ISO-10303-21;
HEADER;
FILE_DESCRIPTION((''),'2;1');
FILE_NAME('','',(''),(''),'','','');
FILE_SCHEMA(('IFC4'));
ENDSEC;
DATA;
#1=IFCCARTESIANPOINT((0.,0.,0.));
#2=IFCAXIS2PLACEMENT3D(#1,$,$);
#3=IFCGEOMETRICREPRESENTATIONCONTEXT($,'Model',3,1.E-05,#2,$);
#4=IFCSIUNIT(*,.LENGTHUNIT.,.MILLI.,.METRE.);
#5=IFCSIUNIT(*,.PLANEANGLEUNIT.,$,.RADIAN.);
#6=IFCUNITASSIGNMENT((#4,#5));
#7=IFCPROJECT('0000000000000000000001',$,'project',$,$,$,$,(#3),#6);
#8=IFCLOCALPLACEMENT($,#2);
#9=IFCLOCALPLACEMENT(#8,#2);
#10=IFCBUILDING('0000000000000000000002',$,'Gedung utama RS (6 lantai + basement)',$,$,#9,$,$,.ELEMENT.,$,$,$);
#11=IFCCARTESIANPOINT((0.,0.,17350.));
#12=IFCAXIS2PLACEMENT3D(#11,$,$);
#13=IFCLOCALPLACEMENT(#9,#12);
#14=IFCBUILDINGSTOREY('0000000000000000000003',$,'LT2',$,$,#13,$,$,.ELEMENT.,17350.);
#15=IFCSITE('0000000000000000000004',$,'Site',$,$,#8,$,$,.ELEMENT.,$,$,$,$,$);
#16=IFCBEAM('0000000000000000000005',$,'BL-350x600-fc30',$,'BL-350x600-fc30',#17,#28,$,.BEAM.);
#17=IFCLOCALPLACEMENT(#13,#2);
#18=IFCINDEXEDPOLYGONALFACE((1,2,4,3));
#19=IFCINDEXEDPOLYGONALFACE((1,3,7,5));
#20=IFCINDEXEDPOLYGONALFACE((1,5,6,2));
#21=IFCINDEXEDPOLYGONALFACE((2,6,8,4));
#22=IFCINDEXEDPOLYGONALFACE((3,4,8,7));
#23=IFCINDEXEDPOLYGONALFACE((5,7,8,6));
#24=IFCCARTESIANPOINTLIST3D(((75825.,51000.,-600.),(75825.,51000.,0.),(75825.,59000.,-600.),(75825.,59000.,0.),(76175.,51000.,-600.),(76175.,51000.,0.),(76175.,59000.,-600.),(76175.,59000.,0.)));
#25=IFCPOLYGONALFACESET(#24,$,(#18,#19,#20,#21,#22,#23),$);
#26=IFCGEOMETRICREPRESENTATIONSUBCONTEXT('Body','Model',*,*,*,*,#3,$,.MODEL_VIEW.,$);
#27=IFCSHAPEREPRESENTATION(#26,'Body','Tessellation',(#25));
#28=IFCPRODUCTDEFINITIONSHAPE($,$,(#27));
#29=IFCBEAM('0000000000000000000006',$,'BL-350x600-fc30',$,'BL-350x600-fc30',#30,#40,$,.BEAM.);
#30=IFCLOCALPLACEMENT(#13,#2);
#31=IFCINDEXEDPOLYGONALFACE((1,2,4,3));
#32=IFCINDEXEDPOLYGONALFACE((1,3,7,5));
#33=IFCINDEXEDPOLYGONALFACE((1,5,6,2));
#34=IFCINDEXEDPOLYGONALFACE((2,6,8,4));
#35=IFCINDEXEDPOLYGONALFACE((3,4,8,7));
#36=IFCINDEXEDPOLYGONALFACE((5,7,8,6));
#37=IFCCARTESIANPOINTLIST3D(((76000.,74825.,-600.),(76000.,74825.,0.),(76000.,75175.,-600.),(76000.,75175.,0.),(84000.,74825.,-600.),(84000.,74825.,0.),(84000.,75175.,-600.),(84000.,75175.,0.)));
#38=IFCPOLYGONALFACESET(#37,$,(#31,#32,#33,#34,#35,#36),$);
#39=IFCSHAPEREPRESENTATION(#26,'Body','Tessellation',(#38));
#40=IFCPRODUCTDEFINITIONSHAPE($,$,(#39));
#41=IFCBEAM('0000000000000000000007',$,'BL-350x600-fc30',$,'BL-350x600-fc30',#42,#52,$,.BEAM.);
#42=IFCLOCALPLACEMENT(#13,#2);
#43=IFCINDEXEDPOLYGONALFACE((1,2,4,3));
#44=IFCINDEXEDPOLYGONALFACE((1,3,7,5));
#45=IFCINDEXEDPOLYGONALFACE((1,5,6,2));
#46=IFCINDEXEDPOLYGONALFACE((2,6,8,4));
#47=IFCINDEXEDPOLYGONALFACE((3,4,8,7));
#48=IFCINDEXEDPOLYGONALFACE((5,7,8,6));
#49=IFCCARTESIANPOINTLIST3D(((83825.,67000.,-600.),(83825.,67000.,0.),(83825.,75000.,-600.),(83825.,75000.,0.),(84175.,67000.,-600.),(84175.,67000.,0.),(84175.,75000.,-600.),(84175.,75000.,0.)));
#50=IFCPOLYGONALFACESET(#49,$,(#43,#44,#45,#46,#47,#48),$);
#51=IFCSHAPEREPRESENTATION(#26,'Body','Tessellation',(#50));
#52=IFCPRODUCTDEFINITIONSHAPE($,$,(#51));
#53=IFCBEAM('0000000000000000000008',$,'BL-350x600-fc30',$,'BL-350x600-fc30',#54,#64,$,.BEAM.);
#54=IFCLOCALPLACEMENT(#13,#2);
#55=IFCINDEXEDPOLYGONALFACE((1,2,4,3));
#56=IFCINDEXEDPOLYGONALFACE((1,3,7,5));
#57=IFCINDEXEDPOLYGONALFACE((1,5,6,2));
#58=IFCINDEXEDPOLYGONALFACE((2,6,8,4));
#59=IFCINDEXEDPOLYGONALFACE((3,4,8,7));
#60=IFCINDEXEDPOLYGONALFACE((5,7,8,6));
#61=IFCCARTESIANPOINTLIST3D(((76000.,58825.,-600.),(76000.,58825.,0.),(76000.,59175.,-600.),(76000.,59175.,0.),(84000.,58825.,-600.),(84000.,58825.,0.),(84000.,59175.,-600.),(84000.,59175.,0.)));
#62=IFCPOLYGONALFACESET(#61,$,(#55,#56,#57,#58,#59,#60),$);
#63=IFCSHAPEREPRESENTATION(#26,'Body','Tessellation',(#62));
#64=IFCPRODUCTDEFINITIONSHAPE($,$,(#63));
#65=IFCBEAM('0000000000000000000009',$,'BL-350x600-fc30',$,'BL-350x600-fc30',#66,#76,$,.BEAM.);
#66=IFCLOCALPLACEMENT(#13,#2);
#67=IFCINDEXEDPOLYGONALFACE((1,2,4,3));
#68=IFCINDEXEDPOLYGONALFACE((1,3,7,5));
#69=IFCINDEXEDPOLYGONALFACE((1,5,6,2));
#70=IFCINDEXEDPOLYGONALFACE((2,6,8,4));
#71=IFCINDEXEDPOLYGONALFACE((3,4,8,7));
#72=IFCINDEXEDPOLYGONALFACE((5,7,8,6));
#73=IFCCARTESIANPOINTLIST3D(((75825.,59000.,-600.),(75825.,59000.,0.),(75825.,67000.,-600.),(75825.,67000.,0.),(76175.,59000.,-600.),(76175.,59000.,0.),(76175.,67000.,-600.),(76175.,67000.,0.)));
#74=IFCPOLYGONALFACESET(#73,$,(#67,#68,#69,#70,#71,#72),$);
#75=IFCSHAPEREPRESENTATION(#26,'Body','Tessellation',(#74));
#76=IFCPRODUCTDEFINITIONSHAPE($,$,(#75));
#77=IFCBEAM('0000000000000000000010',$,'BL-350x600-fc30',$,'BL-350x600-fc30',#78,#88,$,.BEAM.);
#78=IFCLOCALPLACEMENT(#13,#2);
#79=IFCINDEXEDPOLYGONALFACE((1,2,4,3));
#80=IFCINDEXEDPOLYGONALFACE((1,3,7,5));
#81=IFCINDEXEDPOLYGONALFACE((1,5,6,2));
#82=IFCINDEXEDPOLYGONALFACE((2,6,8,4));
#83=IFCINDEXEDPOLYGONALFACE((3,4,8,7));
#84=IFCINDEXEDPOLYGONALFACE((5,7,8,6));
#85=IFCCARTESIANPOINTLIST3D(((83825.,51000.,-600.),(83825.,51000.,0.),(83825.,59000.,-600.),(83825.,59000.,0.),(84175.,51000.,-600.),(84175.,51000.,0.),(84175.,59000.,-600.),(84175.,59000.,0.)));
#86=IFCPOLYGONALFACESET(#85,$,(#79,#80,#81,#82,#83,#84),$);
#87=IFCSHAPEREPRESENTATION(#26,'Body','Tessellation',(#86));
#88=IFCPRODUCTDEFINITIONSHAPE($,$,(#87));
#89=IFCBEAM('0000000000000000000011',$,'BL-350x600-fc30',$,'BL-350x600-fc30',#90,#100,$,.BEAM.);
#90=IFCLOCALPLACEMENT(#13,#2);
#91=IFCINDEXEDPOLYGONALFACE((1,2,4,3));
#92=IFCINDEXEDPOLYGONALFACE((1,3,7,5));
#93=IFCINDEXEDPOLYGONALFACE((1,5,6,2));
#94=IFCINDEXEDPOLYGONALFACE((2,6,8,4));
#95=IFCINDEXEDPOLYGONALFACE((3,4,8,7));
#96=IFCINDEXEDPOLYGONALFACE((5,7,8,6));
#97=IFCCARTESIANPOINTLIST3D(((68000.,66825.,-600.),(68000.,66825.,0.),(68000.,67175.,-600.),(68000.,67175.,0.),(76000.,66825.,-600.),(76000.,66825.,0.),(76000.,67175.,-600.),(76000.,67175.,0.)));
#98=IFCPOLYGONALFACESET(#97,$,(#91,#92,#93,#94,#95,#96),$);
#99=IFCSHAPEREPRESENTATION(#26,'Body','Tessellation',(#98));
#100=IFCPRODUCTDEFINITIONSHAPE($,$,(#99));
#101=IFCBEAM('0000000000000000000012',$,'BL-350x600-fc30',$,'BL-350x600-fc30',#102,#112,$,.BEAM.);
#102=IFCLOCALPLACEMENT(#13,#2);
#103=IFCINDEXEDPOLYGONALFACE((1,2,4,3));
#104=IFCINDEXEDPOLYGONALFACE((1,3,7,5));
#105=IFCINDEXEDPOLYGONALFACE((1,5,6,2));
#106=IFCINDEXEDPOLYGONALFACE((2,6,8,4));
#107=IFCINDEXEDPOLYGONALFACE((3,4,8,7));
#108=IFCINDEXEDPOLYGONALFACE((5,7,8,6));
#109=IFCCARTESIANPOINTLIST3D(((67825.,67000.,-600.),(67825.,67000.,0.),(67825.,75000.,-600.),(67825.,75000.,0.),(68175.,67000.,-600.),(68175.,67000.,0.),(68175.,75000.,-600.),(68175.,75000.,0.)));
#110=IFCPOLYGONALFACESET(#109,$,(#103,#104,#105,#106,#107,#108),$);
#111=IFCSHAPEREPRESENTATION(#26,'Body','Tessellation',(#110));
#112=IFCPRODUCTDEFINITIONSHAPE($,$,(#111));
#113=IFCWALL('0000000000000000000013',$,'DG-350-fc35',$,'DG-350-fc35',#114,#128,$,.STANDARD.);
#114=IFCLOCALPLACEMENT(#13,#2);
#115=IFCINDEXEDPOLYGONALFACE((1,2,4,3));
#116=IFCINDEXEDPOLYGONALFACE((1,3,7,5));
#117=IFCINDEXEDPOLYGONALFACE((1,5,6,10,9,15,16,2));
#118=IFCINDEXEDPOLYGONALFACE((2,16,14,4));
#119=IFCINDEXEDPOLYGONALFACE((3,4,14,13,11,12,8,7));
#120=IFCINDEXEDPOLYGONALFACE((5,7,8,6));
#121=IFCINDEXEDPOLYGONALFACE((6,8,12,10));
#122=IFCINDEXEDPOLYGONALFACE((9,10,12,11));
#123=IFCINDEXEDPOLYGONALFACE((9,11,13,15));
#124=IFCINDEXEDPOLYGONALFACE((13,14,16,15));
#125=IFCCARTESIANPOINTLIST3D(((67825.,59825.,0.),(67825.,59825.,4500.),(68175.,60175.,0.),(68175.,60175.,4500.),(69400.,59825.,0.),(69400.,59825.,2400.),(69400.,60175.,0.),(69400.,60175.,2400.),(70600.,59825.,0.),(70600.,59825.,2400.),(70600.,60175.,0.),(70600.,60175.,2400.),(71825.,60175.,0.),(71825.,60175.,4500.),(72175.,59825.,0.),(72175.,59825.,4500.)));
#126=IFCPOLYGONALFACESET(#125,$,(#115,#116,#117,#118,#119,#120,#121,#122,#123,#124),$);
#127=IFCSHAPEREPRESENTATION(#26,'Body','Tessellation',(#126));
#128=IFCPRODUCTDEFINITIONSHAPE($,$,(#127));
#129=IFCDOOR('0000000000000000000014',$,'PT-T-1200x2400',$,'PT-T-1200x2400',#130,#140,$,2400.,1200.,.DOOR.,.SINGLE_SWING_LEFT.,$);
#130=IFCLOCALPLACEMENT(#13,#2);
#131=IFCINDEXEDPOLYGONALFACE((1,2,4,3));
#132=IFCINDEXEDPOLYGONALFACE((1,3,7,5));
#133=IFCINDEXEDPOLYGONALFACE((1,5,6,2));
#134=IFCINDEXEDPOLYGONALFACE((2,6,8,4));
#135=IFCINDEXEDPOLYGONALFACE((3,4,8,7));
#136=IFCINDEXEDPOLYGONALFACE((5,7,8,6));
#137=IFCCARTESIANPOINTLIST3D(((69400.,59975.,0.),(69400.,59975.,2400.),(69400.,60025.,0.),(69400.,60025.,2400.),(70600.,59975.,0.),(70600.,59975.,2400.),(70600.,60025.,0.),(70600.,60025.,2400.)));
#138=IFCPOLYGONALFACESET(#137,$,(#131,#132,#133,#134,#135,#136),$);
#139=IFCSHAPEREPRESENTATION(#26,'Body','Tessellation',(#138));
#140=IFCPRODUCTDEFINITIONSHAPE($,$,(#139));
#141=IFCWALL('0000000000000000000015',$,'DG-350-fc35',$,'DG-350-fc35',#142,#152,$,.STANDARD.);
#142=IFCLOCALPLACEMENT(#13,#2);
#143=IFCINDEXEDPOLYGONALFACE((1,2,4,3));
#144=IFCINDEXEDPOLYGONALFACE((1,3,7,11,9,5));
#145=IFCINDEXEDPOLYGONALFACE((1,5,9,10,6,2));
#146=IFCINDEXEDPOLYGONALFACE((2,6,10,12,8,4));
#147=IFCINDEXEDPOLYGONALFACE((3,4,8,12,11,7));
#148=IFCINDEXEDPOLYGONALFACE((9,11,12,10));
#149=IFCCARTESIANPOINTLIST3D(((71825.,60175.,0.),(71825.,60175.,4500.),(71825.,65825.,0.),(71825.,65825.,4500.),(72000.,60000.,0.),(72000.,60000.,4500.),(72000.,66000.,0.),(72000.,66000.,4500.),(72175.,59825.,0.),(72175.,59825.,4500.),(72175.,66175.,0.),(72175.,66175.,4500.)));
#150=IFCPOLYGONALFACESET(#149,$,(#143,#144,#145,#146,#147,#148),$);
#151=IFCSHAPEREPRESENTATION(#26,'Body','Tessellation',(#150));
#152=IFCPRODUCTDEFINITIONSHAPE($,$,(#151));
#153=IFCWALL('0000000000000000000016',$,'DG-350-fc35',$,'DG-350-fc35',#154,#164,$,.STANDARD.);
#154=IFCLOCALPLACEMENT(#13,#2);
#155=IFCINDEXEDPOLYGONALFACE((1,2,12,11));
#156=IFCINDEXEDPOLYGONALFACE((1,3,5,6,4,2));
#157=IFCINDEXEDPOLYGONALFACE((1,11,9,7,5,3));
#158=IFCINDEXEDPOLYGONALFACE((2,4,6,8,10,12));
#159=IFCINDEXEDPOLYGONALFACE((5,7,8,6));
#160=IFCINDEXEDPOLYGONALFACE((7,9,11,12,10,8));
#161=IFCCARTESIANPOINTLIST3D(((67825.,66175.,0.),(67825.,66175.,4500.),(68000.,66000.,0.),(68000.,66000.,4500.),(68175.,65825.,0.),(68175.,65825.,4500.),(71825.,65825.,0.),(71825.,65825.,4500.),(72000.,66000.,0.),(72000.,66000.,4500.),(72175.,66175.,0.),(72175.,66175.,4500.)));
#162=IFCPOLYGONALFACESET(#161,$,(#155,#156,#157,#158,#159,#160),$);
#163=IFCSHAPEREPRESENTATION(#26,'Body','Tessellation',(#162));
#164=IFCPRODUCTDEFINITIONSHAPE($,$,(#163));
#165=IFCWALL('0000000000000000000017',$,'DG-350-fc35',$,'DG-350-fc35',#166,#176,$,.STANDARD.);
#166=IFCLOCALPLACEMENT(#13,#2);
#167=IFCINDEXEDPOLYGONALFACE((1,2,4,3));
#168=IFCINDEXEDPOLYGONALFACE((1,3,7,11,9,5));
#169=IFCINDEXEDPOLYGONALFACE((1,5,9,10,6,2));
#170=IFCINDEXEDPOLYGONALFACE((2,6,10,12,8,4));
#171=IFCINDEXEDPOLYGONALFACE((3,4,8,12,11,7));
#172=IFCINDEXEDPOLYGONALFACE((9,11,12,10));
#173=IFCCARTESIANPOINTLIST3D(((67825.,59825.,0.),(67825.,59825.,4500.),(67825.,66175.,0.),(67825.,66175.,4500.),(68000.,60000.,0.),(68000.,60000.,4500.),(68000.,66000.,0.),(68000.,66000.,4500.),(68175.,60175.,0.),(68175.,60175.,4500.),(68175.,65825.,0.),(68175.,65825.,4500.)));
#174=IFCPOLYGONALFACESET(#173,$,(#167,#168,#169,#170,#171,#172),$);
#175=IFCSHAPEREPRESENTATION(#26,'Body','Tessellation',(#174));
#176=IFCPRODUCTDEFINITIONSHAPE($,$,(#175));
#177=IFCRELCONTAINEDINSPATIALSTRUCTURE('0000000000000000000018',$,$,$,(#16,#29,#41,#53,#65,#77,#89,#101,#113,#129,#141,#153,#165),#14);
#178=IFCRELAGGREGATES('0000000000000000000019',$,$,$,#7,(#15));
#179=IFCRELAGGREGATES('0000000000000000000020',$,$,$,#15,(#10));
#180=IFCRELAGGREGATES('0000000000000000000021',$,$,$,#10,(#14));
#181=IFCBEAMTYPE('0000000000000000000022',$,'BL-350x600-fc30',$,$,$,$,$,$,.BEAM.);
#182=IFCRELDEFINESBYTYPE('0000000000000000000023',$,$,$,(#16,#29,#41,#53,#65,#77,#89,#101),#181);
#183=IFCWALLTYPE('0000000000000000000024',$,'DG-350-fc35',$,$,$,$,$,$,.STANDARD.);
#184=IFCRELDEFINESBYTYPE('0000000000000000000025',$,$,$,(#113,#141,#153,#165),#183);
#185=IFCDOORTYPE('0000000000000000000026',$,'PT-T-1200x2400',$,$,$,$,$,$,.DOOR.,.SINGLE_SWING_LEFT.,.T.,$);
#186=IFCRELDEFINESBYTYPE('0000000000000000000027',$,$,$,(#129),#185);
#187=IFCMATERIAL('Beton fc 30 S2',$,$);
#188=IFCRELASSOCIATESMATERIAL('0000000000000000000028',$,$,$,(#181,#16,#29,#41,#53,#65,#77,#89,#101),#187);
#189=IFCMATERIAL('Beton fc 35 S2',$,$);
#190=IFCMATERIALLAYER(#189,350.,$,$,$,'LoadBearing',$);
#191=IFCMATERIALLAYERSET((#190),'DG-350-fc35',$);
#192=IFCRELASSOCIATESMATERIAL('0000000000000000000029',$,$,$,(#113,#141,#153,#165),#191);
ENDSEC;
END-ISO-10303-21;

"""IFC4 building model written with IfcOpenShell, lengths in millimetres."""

from ifc_helpers import new_model, si_unit, frame, frame_2d, origin, origin_2d, place, context, subcontext, project, spatial, polyline, rectangle, outline, extrude, material, layer, layer_set, layer_usage, material_profile, profile_set, profile_usage, type_object, element, fill, save


model = new_model("IFC4")

# Units and contexts
model_context = context("Model", 3, precision=1e-05, world=origin())
body_context = subcontext(model_context, "Body", "Model", "MODEL_VIEW")
ifc_project = project(units=[si_unit("LENGTHUNIT", "METRE", prefix="MILLI"), si_unit("PLANEANGLEUNIT", "RADIAN")], contexts=[model_context])

# Site, building, storey
site_placement = place(None, origin())
site = spatial("IfcSite", under=ifc_project, at=site_placement, Name="Site", CompositionType="ELEMENT")
building_placement = place(site_placement, origin())
building = spatial("IfcBuilding", under=site, at=building_placement, Name="Gedung utama RS (6 lantai + basement)", CompositionType="ELEMENT")
storey_placement = place(building_placement, frame((0.0, 0.0, 17350.0)))
storey = spatial("IfcBuildingStorey", under=building, at=storey_placement, Name="LT2", CompositionType="ELEMENT", Elevation=17350.0)

# Beams
ifc_material_1 = material(Name="Beton fc 30 S2")
ifc_material_profile_1 = material_profile(ifc_material_1, rectangle(XDim=350.0, YDim=600.0, at=origin_2d()), Name="BL-350x600-fc30")
ifc_profile_set_1 = profile_set([ifc_material_profile_1], Name="BL-350x600-fc30")
ifc_profile_usage_1 = profile_usage(ifc_profile_set_1, cardinal=8)
beam_type = type_object("IfcBeamType", Name="BL-350x600-fc30", PredefinedType="BEAM", material=ifc_profile_set_1)
beam_1_placement = place(storey_placement, frame((76000.0, 51000.0, -300.0)))
element("IfcBeam", 1, at=beam_1_placement, inside=storey, type_object=beam_type, material=ifc_profile_usage_1, Name="BL-350x600-fc30", ObjectType="BL-350x600-fc30", PredefinedType="BEAM", context=body_context, shape_type="SweptSolid", body=[
    extrude(rectangle(XDim=350.0, YDim=600.0, at=origin_2d()), frame((0.0, 0.0, 0.0), z_axis=(0.0, 1.0, 0.0), x_axis=(-1.0, 0.0, 0.0)), (0.0, 0.0, 1.0), 8000.0),
])
beam_2_placement = place(storey_placement, frame((76000.0, 75000.0, -300.0)))
element("IfcBeam", 2, at=beam_2_placement, inside=storey, type_object=beam_type, material=ifc_profile_usage_1, Name="BL-350x600-fc30", ObjectType="BL-350x600-fc30", PredefinedType="BEAM", context=body_context, shape_type="SweptSolid", body=[
    extrude(rectangle(XDim=350.0, YDim=600.0, at=origin_2d()), frame((0.0, 0.0, 0.0), z_axis=(1.0, 0.0, 0.0), x_axis=(0.0, 1.0, 0.0)), (0.0, 0.0, 1.0), 8000.0),
])
beam_3_placement = place(storey_placement, frame((84000.0, 67000.0, -300.0)))
element("IfcBeam", 3, at=beam_3_placement, inside=storey, type_object=beam_type, material=ifc_profile_usage_1, Name="BL-350x600-fc30", ObjectType="BL-350x600-fc30", PredefinedType="BEAM", context=body_context, shape_type="SweptSolid", body=[
    extrude(rectangle(XDim=350.0, YDim=600.0, at=origin_2d()), frame((0.0, 0.0, 0.0), z_axis=(0.0, 1.0, 0.0), x_axis=(-1.0, 0.0, 0.0)), (0.0, 0.0, 1.0), 8000.0),
])
beam_4_placement = place(storey_placement, frame((76000.0, 59000.0, -300.0)))
element("IfcBeam", 4, at=beam_4_placement, inside=storey, type_object=beam_type, material=ifc_profile_usage_1, Name="BL-350x600-fc30", ObjectType="BL-350x600-fc30", PredefinedType="BEAM", context=body_context, shape_type="SweptSolid", body=[
    extrude(rectangle(XDim=350.0, YDim=600.0, at=origin_2d()), frame((0.0, 0.0, 0.0), z_axis=(1.0, 0.0, 0.0), x_axis=(0.0, 1.0, 0.0)), (0.0, 0.0, 1.0), 8000.0),
])
for number, where, name in (
    (5, (76000.0, 59000.0, -300.0), "BL-350x600-fc30"),
    (6, (84000.0, 51000.0, -300.0), "BL-350x600-fc30"),
):
    element("IfcBeam", number, at=place(storey_placement, frame(where)), inside=storey, type_object=beam_type, material=ifc_profile_usage_1, Name=name, ObjectType="BL-350x600-fc30", PredefinedType="BEAM", context=body_context, shape_type="SweptSolid", body=[
        extrude(rectangle(XDim=350.0, YDim=600.0, at=origin_2d()), frame((0.0, 0.0, 0.0), z_axis=(0.0, 1.0, 0.0), x_axis=(-1.0, 0.0, 0.0)), (0.0, 0.0, 1.0), 8000.0),
    ])
beam_5_placement = place(storey_placement, frame((68000.0, 67000.0, -300.0)))
element("IfcBeam", 7, at=beam_5_placement, inside=storey, type_object=beam_type, material=ifc_profile_usage_1, Name="BL-350x600-fc30", ObjectType="BL-350x600-fc30", PredefinedType="BEAM", context=body_context, shape_type="SweptSolid", body=[
    extrude(rectangle(XDim=350.0, YDim=600.0, at=origin_2d()), frame((0.0, 0.0, 0.0), z_axis=(1.0, 0.0, 0.0), x_axis=(0.0, 1.0, 0.0)), (0.0, 0.0, 1.0), 8000.0),
])
beam_6_placement = place(storey_placement, frame((68000.0, 67000.0, -300.0)))
element("IfcBeam", 8, at=beam_6_placement, inside=storey, type_object=beam_type, material=ifc_profile_usage_1, Name="BL-350x600-fc30", ObjectType="BL-350x600-fc30", PredefinedType="BEAM", context=body_context, shape_type="SweptSolid", body=[
    extrude(rectangle(XDim=350.0, YDim=600.0, at=origin_2d()), frame((0.0, 0.0, 0.0), z_axis=(0.0, 1.0, 0.0), x_axis=(-1.0, 0.0, 0.0)), (0.0, 0.0, 1.0), 8000.0),
])

# Wall, opening, door
ifc_material_2 = material(Name="Beton fc 35 S2")
ifc_layer = layer(ifc_material_2, 350.0, Category="LoadBearing")
ifc_layer_set = layer_set([ifc_layer], Name="DG-350-fc35")
ifc_layer_usage = layer_usage(ifc_layer_set, "AXIS2", "NEGATIVE", 175.0)
wall_type = type_object("IfcWallType", Name="DG-350-fc35", PredefinedType="STANDARD")
wall_1_placement = place(storey_placement, frame((68000.0, 60000.0, 0.0), z_axis=(0.0, 0.0, 1.0), x_axis=(1.0, 0.0, 0.0)))
wall_1 = element("IfcWall", 9, at=wall_1_placement, inside=storey, type_object=wall_type, material=ifc_layer_usage, Name="DG-350-fc35", ObjectType="DG-350-fc35", PredefinedType="STANDARD", context=body_context, shape_type="SweptSolid", body=[
    extrude(outline(polyline([(-175.0, -175.0), (0.0, 0.0), (175.0, 175.0), (3825.0, 175.0), (4000.0, 0.0), (4175.0, -175.0), (-175.0, -175.0)])), origin(), (0.0, 0.0, 1.0), 4500.0),
])
opening_placement = place(wall_1_placement, frame((1400.0, 0.0, 0.0), z_axis=(0.0, 0.0, 1.0), x_axis=(1.0, 0.0, 0.0)))
opening = element("IfcOpeningElement", 10, at=opening_placement, cuts=wall_1, PredefinedType="OPENING", context=body_context, shape_type="SweptSolid", body=[
    extrude(rectangle(XDim=1200.0, YDim=370.0, at=frame_2d((600.0, 0.0))), origin(), (0.0, 0.0, 1.0), 2400.0),
])
door_type = type_object("IfcDoorType", Name="PT-T-1200x2400", OperationType="SINGLE_SWING_LEFT", ParameterTakesPrecedence=True, PredefinedType="DOOR")
door_placement = place(opening_placement, origin())
door = element("IfcDoor", 11, at=door_placement, inside=storey, type_object=door_type, Name="PT-T-1200x2400", ObjectType="PT-T-1200x2400", OperationType="SINGLE_SWING_LEFT", OverallHeight=2400.0, OverallWidth=1200.0, PredefinedType="DOOR", context=body_context, shape_type="SweptSolid", body=[
    extrude(rectangle(XDim=1200.0, YDim=50.0, at=frame_2d((600.0, 0.0))), origin(), (0.0, 0.0, 1.0), 2400.0),
])
fill(opening, door)

# Walls
wall_2_placement = place(storey_placement, frame((72000.0, 60000.0, 0.0), z_axis=(0.0, 0.0, 1.0), x_axis=(0.0, 1.0, 0.0)))
element("IfcWall", 12, at=wall_2_placement, inside=storey, type_object=wall_type, material=ifc_layer_usage, Name="DG-350-fc35", ObjectType="DG-350-fc35", PredefinedType="STANDARD", context=body_context, shape_type="SweptSolid", body=[
    extrude(outline(polyline([(-175.0, -175.0), (0.0, 0.0), (175.0, 175.0), (5825.0, 175.0), (6000.0, 0.0), (6175.0, -175.0), (-175.0, -175.0)])), origin(), (0.0, 0.0, 1.0), 4500.0),
])
wall_3_placement = place(storey_placement, frame((72000.0, 66000.0, 0.0), z_axis=(0.0, 0.0, 1.0), x_axis=(-1.0, 0.0, 0.0)))
element("IfcWall", 13, at=wall_3_placement, inside=storey, type_object=wall_type, material=ifc_layer_usage, Name="DG-350-fc35", ObjectType="DG-350-fc35", PredefinedType="STANDARD", context=body_context, shape_type="SweptSolid", body=[
    extrude(outline(polyline([(-175.0, -175.0), (0.0, 0.0), (175.0, 175.0), (3825.0, 175.0), (4000.0, 0.0), (4175.0, -175.0), (-175.0, -175.0)])), origin(), (0.0, 0.0, 1.0), 4500.0),
])
wall_4_placement = place(storey_placement, frame((68000.0, 66000.0, 0.0), z_axis=(0.0, 0.0, 1.0), x_axis=(0.0, -1.0, 0.0)))
element("IfcWall", 14, at=wall_4_placement, inside=storey, type_object=wall_type, material=ifc_layer_usage, Name="DG-350-fc35", ObjectType="DG-350-fc35", PredefinedType="STANDARD", context=body_context, shape_type="SweptSolid", body=[
    extrude(outline(polyline([(-175.0, -175.0), (0.0, 0.0), (175.0, 175.0), (5825.0, 175.0), (6000.0, 0.0), (6175.0, -175.0), (-175.0, -175.0)])), origin(), (0.0, 0.0, 1.0), 4500.0),
])

save(model, "model.ifc")
